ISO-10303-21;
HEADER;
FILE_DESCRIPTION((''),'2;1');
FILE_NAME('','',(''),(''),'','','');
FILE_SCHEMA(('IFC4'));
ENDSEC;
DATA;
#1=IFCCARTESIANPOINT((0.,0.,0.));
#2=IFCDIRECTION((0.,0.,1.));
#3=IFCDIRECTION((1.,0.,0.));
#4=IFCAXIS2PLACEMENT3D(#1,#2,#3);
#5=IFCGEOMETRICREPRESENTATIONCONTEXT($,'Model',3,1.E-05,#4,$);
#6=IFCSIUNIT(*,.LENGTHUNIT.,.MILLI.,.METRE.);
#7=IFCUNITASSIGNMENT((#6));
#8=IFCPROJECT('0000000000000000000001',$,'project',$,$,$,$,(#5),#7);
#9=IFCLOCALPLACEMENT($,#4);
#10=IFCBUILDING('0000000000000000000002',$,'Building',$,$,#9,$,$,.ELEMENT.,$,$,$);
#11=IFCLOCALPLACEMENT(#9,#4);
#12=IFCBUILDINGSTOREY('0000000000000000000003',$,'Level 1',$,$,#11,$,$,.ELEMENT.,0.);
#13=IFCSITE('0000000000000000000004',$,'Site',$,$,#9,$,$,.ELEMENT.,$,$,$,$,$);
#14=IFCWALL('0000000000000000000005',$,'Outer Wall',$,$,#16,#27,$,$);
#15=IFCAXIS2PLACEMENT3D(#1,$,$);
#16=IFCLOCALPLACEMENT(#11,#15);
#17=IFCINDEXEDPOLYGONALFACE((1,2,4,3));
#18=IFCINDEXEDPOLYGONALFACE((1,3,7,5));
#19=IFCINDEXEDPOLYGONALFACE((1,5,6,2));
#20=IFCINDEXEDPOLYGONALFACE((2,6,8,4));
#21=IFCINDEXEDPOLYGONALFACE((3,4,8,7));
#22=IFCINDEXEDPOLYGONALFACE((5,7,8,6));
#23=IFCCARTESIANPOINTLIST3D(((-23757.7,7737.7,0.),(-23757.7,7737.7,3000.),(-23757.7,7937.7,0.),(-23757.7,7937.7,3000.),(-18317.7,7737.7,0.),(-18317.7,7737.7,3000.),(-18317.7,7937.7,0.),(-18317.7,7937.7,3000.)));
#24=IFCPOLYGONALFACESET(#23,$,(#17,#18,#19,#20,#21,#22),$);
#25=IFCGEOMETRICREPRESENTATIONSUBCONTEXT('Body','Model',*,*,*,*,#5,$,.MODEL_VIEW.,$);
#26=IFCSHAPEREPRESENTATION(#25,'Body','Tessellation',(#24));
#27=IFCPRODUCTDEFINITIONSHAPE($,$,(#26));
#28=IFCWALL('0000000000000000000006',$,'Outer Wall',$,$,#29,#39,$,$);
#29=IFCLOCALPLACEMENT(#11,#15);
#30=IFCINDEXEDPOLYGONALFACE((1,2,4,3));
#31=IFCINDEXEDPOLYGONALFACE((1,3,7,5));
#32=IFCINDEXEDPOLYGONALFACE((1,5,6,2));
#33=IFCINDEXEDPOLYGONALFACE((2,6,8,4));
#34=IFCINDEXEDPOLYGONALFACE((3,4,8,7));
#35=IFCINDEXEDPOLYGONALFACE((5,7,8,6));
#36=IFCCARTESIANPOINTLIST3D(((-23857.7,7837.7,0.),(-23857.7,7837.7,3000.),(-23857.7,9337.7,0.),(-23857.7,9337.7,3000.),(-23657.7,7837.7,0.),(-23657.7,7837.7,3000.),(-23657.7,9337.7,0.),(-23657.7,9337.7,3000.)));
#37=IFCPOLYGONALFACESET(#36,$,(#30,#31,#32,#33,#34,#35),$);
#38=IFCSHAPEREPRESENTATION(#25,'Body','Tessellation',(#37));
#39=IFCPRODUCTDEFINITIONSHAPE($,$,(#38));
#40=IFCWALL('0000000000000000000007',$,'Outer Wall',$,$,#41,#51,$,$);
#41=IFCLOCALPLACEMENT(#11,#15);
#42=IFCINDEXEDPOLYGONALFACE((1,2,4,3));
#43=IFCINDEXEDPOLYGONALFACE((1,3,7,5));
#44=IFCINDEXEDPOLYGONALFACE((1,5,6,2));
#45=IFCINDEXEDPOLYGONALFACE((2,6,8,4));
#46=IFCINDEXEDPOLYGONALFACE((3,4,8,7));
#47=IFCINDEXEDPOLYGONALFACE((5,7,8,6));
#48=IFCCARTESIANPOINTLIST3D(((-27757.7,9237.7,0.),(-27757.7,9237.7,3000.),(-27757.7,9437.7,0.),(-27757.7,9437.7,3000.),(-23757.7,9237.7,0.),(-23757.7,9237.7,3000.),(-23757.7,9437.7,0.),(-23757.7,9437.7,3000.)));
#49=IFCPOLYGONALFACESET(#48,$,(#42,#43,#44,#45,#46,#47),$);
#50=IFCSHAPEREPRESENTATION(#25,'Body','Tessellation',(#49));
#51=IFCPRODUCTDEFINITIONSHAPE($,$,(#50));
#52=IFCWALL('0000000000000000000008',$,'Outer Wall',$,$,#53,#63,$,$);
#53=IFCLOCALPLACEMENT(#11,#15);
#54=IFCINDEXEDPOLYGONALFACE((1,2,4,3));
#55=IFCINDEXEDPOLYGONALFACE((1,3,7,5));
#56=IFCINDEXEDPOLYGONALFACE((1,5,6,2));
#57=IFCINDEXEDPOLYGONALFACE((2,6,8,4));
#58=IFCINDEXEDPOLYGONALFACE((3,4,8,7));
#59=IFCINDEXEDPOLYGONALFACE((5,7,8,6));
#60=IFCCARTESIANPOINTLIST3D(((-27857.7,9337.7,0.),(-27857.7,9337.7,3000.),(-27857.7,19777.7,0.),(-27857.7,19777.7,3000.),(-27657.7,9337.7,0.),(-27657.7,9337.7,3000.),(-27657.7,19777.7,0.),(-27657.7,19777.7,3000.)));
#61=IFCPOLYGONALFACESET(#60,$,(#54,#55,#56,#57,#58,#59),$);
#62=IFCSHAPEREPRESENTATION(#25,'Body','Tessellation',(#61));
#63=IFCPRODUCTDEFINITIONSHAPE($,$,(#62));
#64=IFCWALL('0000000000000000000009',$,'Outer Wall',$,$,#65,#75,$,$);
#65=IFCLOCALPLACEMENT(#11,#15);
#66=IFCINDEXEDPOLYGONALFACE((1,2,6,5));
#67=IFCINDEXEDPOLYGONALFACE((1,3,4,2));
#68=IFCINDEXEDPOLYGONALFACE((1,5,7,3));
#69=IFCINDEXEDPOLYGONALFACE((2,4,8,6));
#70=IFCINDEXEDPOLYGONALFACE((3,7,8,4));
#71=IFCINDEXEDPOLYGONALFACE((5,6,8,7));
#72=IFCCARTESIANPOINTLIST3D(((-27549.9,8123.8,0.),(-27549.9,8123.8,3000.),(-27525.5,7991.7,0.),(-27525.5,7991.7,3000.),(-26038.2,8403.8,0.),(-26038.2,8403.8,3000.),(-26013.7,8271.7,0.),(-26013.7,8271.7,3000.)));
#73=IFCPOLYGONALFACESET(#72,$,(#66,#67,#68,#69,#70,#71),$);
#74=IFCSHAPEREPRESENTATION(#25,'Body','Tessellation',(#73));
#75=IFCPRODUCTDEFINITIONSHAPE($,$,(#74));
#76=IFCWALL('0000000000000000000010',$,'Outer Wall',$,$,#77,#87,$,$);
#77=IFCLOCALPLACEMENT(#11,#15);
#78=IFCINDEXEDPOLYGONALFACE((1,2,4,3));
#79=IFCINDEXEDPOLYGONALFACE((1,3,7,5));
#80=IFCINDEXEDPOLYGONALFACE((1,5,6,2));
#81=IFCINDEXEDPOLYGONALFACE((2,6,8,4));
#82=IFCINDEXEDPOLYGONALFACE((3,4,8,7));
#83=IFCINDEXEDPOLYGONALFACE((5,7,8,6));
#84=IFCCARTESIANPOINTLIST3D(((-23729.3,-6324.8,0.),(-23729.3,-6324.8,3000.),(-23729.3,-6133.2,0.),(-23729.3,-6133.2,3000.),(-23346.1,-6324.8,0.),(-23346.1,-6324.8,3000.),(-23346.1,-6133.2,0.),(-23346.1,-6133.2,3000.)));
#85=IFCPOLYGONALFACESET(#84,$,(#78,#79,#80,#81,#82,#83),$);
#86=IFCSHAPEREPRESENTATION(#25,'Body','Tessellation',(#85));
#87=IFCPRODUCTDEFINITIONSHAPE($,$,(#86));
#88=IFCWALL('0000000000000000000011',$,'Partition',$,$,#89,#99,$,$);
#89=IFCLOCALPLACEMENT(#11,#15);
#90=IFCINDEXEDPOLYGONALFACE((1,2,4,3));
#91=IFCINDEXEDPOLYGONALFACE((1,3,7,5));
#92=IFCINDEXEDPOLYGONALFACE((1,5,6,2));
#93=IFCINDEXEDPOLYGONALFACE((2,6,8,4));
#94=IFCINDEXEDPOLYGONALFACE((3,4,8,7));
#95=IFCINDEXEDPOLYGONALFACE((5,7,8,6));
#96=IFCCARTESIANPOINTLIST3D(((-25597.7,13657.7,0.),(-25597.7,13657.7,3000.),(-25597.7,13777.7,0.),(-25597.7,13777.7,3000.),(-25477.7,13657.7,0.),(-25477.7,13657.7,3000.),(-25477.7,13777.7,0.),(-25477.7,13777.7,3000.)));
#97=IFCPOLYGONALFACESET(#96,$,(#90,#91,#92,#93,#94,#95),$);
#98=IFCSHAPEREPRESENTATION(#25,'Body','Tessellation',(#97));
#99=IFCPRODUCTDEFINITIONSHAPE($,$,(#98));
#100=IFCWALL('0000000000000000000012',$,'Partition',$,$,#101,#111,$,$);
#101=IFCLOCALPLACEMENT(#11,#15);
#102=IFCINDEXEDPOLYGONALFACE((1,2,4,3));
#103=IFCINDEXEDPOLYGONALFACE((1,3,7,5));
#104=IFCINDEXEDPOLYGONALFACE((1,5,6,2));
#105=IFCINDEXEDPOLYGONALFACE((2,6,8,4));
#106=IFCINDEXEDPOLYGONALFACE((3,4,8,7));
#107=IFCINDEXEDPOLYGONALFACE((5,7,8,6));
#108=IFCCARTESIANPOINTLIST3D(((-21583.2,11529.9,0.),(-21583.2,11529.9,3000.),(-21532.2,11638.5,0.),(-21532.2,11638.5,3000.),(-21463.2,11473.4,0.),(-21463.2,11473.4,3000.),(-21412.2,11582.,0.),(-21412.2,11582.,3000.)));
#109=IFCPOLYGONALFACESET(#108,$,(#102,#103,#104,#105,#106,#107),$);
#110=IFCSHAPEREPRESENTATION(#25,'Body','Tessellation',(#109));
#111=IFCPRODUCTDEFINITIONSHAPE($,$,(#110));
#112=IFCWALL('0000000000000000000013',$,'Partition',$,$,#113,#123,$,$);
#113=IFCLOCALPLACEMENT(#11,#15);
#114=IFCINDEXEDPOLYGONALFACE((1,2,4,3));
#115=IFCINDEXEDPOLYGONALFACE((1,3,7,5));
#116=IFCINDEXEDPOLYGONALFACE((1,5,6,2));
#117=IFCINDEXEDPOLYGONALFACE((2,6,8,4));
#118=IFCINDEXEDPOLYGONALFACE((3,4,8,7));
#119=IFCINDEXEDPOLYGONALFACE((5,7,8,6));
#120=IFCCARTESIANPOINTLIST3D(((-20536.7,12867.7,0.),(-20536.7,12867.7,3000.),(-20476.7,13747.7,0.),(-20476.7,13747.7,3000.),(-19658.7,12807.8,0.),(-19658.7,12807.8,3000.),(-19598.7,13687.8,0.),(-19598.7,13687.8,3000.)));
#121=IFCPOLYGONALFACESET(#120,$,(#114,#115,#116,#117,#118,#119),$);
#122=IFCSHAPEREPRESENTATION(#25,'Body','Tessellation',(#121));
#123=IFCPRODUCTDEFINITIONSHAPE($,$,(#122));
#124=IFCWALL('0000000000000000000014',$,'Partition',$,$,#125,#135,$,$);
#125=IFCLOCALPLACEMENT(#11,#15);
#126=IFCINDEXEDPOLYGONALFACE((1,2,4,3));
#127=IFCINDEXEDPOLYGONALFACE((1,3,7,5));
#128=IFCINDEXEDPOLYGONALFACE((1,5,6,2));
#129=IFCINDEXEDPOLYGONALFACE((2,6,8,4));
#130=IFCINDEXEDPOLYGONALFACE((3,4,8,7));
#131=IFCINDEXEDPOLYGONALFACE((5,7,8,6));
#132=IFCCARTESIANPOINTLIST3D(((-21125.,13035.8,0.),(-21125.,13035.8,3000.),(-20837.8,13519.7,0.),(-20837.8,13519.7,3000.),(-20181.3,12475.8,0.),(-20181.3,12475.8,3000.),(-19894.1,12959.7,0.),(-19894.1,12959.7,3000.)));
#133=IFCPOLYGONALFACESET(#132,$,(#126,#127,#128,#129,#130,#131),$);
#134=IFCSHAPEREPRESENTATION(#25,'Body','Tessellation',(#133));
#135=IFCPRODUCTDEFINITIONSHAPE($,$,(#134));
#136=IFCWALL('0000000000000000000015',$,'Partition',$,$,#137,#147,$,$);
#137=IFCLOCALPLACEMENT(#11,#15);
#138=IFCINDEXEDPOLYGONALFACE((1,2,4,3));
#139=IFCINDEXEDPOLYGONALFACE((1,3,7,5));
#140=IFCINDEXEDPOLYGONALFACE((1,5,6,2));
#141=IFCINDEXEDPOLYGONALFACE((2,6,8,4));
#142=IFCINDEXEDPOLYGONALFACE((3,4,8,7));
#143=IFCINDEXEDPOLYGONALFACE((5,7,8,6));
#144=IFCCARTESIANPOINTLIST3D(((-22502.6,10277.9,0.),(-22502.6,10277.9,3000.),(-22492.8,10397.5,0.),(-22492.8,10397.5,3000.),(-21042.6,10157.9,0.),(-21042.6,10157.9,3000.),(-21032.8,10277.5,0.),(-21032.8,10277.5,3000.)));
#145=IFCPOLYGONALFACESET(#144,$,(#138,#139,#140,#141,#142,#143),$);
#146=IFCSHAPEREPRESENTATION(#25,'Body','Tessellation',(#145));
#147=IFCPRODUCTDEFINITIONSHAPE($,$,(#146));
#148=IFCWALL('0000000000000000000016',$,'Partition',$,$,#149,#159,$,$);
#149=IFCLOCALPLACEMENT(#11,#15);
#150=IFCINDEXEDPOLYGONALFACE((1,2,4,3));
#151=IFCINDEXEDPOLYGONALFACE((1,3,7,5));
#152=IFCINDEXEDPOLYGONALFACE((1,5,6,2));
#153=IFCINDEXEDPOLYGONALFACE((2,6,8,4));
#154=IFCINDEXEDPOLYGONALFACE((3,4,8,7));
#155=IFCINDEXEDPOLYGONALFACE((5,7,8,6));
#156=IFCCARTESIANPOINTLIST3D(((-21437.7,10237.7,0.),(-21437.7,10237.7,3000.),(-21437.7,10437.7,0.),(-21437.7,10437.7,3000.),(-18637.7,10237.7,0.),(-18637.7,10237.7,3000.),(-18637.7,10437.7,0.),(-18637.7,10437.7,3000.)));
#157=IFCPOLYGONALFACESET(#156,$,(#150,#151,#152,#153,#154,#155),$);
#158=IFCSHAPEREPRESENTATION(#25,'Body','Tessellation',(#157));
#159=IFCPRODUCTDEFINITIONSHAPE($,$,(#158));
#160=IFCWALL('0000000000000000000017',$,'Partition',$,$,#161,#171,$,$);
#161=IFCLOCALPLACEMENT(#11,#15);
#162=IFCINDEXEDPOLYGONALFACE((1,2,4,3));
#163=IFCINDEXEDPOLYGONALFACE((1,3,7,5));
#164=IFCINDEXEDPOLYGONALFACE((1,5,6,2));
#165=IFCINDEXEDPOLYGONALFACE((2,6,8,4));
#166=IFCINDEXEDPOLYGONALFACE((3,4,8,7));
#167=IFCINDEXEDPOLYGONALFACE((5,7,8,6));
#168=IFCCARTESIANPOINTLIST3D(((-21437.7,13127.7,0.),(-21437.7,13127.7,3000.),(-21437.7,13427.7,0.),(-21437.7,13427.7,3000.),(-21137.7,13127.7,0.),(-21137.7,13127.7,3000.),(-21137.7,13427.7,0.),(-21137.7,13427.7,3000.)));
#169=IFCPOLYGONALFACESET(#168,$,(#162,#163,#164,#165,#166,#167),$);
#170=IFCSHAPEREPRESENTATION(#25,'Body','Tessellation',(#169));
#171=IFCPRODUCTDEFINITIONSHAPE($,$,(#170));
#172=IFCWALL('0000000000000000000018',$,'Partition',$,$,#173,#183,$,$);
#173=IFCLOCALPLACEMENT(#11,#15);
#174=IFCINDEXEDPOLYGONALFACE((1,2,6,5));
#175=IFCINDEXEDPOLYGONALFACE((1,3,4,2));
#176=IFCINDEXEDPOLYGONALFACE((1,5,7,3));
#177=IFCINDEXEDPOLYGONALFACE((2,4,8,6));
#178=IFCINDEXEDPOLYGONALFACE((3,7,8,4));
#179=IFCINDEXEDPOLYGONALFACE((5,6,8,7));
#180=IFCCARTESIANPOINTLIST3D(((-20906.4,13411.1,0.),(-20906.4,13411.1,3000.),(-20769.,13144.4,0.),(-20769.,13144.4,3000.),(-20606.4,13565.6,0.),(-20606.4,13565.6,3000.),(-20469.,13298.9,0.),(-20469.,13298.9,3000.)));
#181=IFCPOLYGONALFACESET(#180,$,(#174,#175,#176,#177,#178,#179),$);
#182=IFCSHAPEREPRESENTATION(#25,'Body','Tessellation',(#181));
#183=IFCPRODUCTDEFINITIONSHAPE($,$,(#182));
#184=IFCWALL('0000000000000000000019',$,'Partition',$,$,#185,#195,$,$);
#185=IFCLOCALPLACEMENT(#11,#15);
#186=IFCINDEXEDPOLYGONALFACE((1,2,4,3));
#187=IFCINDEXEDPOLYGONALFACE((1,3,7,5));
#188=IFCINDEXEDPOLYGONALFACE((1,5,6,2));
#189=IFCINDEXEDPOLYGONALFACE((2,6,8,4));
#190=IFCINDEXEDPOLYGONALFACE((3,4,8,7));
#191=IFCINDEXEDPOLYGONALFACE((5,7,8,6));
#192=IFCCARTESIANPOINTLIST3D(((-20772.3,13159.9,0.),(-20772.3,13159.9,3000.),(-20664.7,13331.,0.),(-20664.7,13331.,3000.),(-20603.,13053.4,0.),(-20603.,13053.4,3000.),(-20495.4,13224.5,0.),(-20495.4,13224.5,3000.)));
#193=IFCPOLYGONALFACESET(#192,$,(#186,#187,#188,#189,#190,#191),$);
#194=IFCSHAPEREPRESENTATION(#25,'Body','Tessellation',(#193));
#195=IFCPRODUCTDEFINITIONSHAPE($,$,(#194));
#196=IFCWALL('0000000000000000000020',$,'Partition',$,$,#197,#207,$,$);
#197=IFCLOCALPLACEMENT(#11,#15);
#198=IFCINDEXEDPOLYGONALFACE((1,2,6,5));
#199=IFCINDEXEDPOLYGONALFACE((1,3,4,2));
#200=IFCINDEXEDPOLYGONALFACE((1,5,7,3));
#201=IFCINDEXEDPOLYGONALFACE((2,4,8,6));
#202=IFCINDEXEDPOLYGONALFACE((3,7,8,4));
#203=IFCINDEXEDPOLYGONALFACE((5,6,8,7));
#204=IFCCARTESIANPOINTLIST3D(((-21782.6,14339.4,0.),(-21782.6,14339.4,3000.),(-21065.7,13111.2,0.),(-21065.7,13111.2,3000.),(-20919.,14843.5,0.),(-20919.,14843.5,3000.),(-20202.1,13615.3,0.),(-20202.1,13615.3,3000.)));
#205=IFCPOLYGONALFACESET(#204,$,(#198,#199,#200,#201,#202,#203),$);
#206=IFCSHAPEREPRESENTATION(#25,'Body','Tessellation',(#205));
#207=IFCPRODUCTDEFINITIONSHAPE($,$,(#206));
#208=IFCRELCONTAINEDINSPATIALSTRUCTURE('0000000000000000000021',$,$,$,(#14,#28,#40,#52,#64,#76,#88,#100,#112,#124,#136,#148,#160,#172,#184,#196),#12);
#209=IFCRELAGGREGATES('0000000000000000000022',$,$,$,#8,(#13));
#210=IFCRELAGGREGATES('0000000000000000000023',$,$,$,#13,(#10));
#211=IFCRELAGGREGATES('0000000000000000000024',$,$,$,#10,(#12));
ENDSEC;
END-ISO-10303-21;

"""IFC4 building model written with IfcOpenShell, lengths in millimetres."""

from ifc_helpers import new_model, si_unit, frame, frame_2d, origin_with_axes, place, context, subcontext, project, spatial, rectangle, extrude, element, save


model = new_model("IFC4")

# Units and contexts
model_context = context("Model", 3, precision=1e-05, world=origin_with_axes())
body_context = subcontext(model_context, "Body", "Model", "MODEL_VIEW")
ifc_project = project(units=[si_unit("LENGTHUNIT", "METRE", prefix="MILLI")], contexts=[model_context])

# Site, building, storey
placement = place(None, origin_with_axes())
site = spatial("IfcSite", under=ifc_project, at=placement, Name="Site", CompositionType="ELEMENT")
building = spatial("IfcBuilding", under=site, at=placement, Name="Building", CompositionType="ELEMENT")
storey_placement = place(placement, origin_with_axes())
storey = spatial("IfcBuildingStorey", under=building, at=storey_placement, Name="Level 1", CompositionType="ELEMENT", Elevation=0.0)

# Walls
wall_1_placement = place(placement, frame((-18317.7, 7837.7, 0.0), z_axis=(0.0, 0.0, 1.0), x_axis=(-1.0, 0.0, 0.0)))
element("IfcWall", 1, at=wall_1_placement, inside=storey, Name="Outer Wall", context=body_context, shape_type="SweptSolid", body=[
    extrude(rectangle(XDim=5440.0, YDim=200.0, at=frame_2d((2720.0, 0.0), x_axis=(1.0, 0.0))), origin_with_axes(), (0.0, 0.0, 1.0), 3000.0),
])
wall_2_placement = place(placement, frame((-23757.7, 7837.7, 0.0), z_axis=(0.0, 0.0, 1.0), x_axis=(0.0, 1.0, 0.0)))
element("IfcWall", 2, at=wall_2_placement, inside=storey, Name="Outer Wall", context=body_context, shape_type="SweptSolid", body=[
    extrude(rectangle(XDim=1500.0, YDim=200.0, at=frame_2d((750.0, 0.0), x_axis=(1.0, 0.0))), origin_with_axes(), (0.0, 0.0, 1.0), 3000.0),
])
wall_3_placement = place(placement, frame((-23757.7, 9337.7, 0.0), z_axis=(0.0, 0.0, 1.0), x_axis=(-1.0, 0.0, 0.0)))
element("IfcWall", 3, at=wall_3_placement, inside=storey, Name="Outer Wall", context=body_context, shape_type="SweptSolid", body=[
    extrude(rectangle(XDim=4000.0, YDim=200.0, at=frame_2d((2000.0, 0.0), x_axis=(1.0, 0.0))), origin_with_axes(), (0.0, 0.0, 1.0), 3000.0),
])
wall_4_placement = place(placement, frame((-27757.7, 9337.7, 0.0), z_axis=(0.0, 0.0, 1.0), x_axis=(0.0, 1.0, 0.0)))
element("IfcWall", 4, at=wall_4_placement, inside=storey, Name="Outer Wall", context=body_context, shape_type="SweptSolid", body=[
    extrude(rectangle(XDim=10440.0, YDim=200.0, at=frame_2d((5220.0, 0.0), x_axis=(1.0, 0.0))), origin_with_axes(), (0.0, 0.0, 1.0), 3000.0),
])
wall_5_placement = place(placement, frame((-26025.9, 8337.7, 0.0), z_axis=(0.0, 0.0, 1.0), x_axis=(-0.983277, -0.182117, 0.0)))
element("IfcWall", 5, at=wall_5_placement, inside=storey, Name="Outer Wall", context=body_context, shape_type="SweptSolid", body=[
    extrude(rectangle(XDim=1537.5, YDim=134.4, at=frame_2d((768.7, 0.0), x_axis=(1.0, 0.0))), origin_with_axes(), (0.0, 0.0, 1.0), 3000.0),
])
wall_6_placement = place(placement, frame((-23537.7, -6324.8, 0.0), z_axis=(0.0, 0.0, 1.0), x_axis=(0.0, 1.0, 0.0)))
element("IfcWall", 6, at=wall_6_placement, inside=storey, Name="Outer Wall", context=body_context, shape_type="SweptSolid", body=[
    extrude(rectangle(XDim=191.6, YDim=383.2, at=frame_2d((95.8, 0.0), x_axis=(1.0, 0.0))), origin_with_axes(), (0.0, 0.0, 1.0), 3000.0),
])
wall_7_placement = place(placement, frame((-25537.7, 13657.7, 0.0), z_axis=(0.0, 0.0, 1.0), x_axis=(0.0, 1.0, 0.0)))
element("IfcWall", 7, at=wall_7_placement, inside=storey, Name="Partition", context=body_context, shape_type="SweptSolid", body=[
    extrude(rectangle(XDim=120.0, YDim=120.0, at=frame_2d((60.0, 0.0), x_axis=(1.0, 0.0))), origin_with_axes(), (0.0, 0.0, 1.0), 3000.0),
])
wall_8_placement = place(placement, frame((-21437.7, 11527.7, 0.0), z_axis=(0.0, 0.0, 1.0), x_axis=(-0.904955, 0.425506, 0.0)))
element("IfcWall", 8, at=wall_8_placement, inside=storey, Name="Partition", context=body_context, shape_type="SweptSolid", body=[
    extrude(rectangle(XDim=132.6, YDim=120.0, at=frame_2d((66.3, 0.0), x_axis=(1.0, 0.0))), origin_with_axes(), (0.0, 0.0, 1.0), 3000.0),
])
wall_9_placement = place(placement, frame((-20037.7, 13717.7, 0.0), z_axis=(0.0, 0.0, 1.0), x_axis=(-0.068024, -0.997684, 0.0)))
element("IfcWall", 9, at=wall_9_placement, inside=storey, Name="Partition", context=body_context, shape_type="SweptSolid", body=[
    extrude(rectangle(XDim=882.0, YDim=880.0, at=frame_2d((441.0, 0.0), x_axis=(1.0, 0.0))), origin_with_axes(), (0.0, 0.0, 1.0), 3000.0),
])
wall_10_placement = place(placement, frame((-20037.7, 12717.7, 0.0), z_axis=(0.0, 0.0, 1.0), x_axis=(-0.859984, 0.510322, 0.0)))
element("IfcWall", 10, at=wall_10_placement, inside=storey, Name="Partition", context=body_context, shape_type="SweptSolid", body=[
    extrude(rectangle(XDim=1097.3, YDim=562.7, at=frame_2d((548.7, 0.0), x_axis=(1.0, 0.0))), origin_with_axes(), (0.0, 0.0, 1.0), 3000.0),
])
wall_11_placement = place(placement, frame((-22497.7, 10337.7, 0.0), z_axis=(0.0, 0.0, 1.0), x_axis=(0.996639, -0.081916, 0.0)))
element("IfcWall", 11, at=wall_11_placement, inside=storey, Name="Partition", context=body_context, shape_type="SweptSolid", body=[
    extrude(rectangle(XDim=1464.9, YDim=120.0, at=frame_2d((732.5, 0.0), x_axis=(1.0, 0.0))), origin_with_axes(), (0.0, 0.0, 1.0), 3000.0),
])
wall_12_placement = place(placement, frame((-21437.7, 10337.7, 0.0), z_axis=(0.0, 0.0, 1.0), x_axis=(1.0, 0.0, 0.0)))
element("IfcWall", 12, at=wall_12_placement, inside=storey, Name="Partition", context=body_context, shape_type="SweptSolid", body=[
    extrude(rectangle(XDim=2800.0, YDim=200.0, at=frame_2d((1400.0, 0.0), x_axis=(1.0, 0.0))), origin_with_axes(), (0.0, 0.0, 1.0), 3000.0),
])
wall_13_placement = place(placement, frame((-21437.7, 13277.7, 0.0), z_axis=(0.0, 0.0, 1.0), x_axis=(1.0, 0.0, 0.0)))
element("IfcWall", 13, at=wall_13_placement, inside=storey, Name="Partition", context=body_context, shape_type="SweptSolid", body=[
    extrude(rectangle(XDim=300.0, YDim=300.0, at=frame_2d((150.0, 0.0), x_axis=(1.0, 0.0))), origin_with_axes(), (0.0, 0.0, 1.0), 3000.0),
])
wall_14_placement = place(placement, frame((-20837.7, 13277.7, 0.0), z_axis=(0.0, 0.0, 1.0), x_axis=(0.889014, 0.457879, 0.0)))
element("IfcWall", 14, at=wall_14_placement, inside=storey, Name="Partition", context=body_context, shape_type="SweptSolid", body=[
    extrude(rectangle(XDim=337.5, YDim=300.0, at=frame_2d((168.7, 0.0), x_axis=(1.0, 0.0))), origin_with_axes(), (0.0, 0.0, 1.0), 3000.0),
])
wall_15_placement = place(placement, frame((-20580.1, 13277.7, 0.0), z_axis=(0.0, 0.0, 1.0), x_axis=(-0.532548, -0.8464, 0.0)))
element("IfcWall", 15, at=wall_15_placement, inside=storey, Name="Partition", context=body_context, shape_type="SweptSolid", body=[
    extrude(rectangle(XDim=202.1, YDim=200.0, at=frame_2d((101.0, 0.0), x_axis=(1.0, 0.0))), origin_with_axes(), (0.0, 0.0, 1.0), 3000.0),
])
wall_16_placement = place(placement, frame((-20633.9, 13363.2, 0.0), z_axis=(0.0, 0.0, 1.0), x_axis=(-0.504112, 0.863638, 0.0)))
element("IfcWall", 16, at=wall_16_placement, inside=storey, Name="Partition", context=body_context, shape_type="SweptSolid", body=[
    extrude(rectangle(XDim=1422.1, YDim=1000.0, at=frame_2d((711.1, 0.0), x_axis=(1.0, 0.0))), origin_with_axes(), (0.0, 0.0, 1.0), 3000.0),
])

save(model, "model.ifc")
